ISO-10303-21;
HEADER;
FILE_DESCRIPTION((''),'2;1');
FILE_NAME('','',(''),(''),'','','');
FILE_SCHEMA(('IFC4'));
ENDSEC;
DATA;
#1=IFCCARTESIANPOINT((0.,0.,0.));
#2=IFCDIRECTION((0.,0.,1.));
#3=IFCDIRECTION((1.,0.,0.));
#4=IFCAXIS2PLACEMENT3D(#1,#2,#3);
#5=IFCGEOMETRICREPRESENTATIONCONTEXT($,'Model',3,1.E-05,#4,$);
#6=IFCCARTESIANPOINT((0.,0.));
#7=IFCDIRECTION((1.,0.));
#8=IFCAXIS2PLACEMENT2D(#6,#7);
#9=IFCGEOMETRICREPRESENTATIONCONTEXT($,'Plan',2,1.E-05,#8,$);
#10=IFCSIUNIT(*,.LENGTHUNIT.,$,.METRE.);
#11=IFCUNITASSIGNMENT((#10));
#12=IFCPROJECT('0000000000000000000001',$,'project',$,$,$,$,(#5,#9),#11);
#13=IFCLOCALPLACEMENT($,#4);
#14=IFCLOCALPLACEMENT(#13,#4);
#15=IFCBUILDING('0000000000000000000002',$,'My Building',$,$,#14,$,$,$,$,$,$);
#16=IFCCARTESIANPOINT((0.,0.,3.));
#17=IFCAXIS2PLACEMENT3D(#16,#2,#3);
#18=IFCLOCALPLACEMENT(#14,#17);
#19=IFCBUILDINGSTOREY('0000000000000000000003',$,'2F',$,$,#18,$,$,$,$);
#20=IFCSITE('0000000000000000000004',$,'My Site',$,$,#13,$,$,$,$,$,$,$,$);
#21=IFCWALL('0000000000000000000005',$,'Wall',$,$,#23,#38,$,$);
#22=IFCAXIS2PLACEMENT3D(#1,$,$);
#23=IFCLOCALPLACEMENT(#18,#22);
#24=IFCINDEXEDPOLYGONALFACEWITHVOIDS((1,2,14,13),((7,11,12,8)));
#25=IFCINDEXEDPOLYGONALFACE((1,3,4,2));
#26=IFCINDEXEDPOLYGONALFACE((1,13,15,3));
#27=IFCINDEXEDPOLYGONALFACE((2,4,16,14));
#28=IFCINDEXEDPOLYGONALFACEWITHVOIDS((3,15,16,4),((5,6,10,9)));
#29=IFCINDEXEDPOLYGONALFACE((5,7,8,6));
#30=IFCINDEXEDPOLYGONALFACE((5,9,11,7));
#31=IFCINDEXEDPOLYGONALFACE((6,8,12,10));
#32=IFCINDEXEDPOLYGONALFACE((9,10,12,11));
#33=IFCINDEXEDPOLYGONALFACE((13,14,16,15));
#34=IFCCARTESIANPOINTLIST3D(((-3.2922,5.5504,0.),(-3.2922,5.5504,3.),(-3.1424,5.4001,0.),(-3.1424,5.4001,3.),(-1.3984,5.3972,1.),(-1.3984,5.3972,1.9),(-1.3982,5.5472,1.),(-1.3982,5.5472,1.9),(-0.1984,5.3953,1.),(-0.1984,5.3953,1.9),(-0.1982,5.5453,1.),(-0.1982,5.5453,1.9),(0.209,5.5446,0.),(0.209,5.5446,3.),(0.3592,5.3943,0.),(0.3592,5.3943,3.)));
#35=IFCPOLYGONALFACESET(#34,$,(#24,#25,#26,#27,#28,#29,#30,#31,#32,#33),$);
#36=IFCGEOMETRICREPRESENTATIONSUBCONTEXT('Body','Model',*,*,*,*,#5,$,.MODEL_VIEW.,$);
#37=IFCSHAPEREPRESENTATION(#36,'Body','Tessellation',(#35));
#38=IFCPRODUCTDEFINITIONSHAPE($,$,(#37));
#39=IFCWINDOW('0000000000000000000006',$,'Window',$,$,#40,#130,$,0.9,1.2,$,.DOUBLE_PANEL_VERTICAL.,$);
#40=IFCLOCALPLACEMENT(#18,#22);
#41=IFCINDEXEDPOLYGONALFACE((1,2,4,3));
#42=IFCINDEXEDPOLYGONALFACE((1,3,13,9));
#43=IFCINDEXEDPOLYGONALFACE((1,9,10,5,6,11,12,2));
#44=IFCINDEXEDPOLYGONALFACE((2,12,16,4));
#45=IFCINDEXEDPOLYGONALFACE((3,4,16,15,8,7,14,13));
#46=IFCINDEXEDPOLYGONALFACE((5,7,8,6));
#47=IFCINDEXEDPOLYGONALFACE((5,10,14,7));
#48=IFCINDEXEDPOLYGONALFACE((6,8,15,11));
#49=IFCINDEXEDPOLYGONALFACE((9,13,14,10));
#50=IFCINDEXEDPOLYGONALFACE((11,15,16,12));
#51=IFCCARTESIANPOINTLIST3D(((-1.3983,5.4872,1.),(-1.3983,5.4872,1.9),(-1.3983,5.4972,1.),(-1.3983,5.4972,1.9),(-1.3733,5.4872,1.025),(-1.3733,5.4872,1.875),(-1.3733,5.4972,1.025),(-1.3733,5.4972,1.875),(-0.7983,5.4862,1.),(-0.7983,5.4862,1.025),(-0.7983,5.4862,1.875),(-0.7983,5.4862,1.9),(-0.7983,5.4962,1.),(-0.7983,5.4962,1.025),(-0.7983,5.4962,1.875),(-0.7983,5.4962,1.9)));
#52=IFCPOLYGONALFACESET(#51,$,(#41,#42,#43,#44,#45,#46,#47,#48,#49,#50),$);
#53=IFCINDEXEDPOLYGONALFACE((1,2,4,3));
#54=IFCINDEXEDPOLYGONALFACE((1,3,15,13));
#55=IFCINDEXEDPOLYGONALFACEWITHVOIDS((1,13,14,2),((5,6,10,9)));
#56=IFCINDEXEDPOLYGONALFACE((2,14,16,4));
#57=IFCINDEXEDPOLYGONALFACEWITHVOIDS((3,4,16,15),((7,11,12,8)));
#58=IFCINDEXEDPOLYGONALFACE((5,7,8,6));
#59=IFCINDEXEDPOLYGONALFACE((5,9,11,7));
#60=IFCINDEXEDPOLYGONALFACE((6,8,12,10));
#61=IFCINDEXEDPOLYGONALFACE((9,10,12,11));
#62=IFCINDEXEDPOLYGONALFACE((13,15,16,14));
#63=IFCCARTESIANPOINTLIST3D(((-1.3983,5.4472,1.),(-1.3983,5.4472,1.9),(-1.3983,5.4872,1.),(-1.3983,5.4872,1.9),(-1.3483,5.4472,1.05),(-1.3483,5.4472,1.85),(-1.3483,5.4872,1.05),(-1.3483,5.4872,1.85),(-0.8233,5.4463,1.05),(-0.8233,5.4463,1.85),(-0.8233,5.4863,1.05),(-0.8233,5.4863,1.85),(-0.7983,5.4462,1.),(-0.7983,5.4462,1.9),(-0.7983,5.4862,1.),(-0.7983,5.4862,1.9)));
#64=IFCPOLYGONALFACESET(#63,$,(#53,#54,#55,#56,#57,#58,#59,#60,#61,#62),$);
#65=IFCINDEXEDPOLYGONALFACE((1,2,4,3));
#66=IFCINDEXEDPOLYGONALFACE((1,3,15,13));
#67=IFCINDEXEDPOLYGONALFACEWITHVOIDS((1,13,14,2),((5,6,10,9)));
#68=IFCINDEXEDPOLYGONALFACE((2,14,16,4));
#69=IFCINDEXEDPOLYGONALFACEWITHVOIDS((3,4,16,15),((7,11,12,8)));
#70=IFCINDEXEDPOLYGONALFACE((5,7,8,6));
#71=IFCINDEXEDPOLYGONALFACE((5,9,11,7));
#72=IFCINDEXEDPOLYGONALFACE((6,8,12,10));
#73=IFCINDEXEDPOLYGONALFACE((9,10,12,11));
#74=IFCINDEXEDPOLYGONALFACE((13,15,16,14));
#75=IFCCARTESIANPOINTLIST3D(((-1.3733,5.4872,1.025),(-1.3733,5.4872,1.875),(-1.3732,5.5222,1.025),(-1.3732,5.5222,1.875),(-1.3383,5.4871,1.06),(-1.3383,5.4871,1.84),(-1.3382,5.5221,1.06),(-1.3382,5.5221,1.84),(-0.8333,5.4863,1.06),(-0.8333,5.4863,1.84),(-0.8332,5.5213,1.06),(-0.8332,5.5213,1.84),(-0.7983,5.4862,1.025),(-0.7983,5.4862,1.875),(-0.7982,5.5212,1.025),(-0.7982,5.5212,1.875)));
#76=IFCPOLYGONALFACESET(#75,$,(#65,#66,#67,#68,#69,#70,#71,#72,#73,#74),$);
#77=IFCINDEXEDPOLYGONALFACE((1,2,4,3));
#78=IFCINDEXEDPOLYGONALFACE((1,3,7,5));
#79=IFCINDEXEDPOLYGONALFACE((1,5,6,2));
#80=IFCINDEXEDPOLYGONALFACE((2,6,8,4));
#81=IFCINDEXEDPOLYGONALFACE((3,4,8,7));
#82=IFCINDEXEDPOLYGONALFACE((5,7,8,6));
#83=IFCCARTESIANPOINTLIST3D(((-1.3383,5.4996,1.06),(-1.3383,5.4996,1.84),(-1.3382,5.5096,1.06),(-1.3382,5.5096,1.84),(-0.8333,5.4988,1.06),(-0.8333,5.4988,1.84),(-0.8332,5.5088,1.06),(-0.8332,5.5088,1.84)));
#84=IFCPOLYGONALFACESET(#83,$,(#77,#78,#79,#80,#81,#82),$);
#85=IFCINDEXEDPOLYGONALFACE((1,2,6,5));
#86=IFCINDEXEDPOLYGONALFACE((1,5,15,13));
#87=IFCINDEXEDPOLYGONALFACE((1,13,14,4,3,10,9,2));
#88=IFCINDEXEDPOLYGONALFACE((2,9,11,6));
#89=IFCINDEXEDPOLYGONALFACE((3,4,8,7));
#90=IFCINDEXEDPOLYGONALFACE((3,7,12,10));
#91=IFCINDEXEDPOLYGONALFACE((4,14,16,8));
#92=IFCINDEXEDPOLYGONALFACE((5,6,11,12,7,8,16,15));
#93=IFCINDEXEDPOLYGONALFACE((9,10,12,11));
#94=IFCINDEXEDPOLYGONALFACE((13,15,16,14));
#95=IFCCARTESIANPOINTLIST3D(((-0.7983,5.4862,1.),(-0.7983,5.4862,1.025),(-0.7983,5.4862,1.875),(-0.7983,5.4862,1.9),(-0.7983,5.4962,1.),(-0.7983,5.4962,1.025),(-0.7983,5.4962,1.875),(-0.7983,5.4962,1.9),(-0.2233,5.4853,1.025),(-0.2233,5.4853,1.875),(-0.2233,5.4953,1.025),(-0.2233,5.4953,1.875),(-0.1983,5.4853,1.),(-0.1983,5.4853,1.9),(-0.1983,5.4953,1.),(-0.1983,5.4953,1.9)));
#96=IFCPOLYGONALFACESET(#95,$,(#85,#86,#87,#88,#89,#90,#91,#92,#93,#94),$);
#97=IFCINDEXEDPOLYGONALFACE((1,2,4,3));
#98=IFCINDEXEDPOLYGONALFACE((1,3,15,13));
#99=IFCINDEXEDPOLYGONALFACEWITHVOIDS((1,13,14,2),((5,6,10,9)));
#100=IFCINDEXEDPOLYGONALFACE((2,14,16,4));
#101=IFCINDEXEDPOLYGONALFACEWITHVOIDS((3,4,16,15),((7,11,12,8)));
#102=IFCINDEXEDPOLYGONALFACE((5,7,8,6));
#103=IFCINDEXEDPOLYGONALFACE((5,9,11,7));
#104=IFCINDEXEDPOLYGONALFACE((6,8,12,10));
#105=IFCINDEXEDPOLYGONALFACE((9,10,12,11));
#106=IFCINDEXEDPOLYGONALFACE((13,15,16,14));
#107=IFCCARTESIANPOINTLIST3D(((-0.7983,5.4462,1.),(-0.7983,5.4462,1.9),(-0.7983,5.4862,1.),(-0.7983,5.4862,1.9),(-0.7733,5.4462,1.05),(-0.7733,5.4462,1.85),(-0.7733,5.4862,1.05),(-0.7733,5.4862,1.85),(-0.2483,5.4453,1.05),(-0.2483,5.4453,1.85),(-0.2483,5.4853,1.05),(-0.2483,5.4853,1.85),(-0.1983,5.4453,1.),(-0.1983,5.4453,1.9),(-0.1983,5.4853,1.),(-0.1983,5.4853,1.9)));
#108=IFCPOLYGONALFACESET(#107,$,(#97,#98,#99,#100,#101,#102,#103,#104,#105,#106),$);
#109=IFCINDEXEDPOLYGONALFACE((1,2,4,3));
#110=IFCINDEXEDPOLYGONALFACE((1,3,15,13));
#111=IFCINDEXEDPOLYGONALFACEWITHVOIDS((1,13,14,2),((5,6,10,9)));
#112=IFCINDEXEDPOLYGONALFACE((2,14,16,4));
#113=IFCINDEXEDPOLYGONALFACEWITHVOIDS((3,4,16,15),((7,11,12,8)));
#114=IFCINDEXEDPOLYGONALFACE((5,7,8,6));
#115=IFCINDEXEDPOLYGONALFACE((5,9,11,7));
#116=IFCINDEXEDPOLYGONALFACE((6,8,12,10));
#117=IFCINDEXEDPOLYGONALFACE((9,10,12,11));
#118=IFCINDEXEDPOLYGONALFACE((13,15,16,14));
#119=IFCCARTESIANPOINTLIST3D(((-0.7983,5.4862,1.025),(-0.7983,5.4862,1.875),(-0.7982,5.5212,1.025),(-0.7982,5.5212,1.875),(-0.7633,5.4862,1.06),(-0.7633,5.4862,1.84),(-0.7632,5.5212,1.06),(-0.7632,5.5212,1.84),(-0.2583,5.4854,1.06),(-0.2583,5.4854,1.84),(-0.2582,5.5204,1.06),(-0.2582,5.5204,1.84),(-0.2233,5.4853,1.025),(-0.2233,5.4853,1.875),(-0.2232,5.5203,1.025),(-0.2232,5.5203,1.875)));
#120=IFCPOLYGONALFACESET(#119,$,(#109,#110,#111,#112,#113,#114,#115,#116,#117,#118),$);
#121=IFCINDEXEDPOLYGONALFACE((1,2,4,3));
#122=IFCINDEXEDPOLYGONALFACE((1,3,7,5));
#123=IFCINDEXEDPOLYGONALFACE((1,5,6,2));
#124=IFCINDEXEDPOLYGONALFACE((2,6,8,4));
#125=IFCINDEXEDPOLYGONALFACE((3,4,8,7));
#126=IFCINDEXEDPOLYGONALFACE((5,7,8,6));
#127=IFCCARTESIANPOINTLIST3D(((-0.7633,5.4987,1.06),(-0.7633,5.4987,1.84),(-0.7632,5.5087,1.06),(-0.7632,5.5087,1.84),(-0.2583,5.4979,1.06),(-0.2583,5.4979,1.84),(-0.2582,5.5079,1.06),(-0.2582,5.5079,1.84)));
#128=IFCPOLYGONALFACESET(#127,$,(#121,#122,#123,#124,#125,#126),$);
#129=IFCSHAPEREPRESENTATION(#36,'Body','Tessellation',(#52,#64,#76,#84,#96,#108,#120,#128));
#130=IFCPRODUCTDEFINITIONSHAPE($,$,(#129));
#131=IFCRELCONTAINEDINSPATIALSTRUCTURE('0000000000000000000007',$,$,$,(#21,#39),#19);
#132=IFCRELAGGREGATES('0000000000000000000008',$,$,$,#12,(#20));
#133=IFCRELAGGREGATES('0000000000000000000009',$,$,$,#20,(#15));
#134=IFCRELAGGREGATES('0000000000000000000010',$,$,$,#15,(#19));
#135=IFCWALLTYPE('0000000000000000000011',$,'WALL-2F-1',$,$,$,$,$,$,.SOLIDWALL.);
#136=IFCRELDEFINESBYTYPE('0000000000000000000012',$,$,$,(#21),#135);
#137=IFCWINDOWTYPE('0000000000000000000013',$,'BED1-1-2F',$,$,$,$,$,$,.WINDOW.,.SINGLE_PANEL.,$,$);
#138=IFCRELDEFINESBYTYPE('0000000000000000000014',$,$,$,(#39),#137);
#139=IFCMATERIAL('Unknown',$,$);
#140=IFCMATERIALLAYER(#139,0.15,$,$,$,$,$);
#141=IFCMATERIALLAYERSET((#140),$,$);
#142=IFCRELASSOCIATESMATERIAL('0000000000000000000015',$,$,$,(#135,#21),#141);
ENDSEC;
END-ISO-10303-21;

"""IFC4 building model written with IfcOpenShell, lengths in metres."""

from ifc_helpers import new_model, entity, si_unit, frame, origin_with_axes, origin_2d_with_axis, place, context, subcontext, project, spatial, line, indexed_curve, outline, extrude, shape, source, transform, mapped, material, layer, layer_set, layer_usage, type_object, type_shapes, element, fill, save


model = new_model("IFC4")

# Units and contexts
model_context = context("Model", 3, precision=1e-05, world=origin_with_axes())
plan_context = context("Plan", 2, precision=1e-05, world=origin_2d_with_axis())
body_context_1 = subcontext(model_context, "Body", "Model", "MODEL_VIEW")
body_context_2 = subcontext(plan_context, "Body", "Plan", "PLAN_VIEW")
ifc_project = project(units=[si_unit("LENGTHUNIT", "METRE")], contexts=[model_context, plan_context])

# Site, building, storey
site_placement = place(None, origin_with_axes())
site = spatial("IfcSite", under=ifc_project, at=site_placement, Name="My Site")
building_placement = place(site_placement, origin_with_axes())
building = spatial("IfcBuilding", under=site, at=building_placement, Name="My Building")
storey_placement = place(building_placement, frame((0.0, 0.0, 3.0), z_axis=(0.0, 0.0, 1.0), x_axis=(1.0, 0.0, 0.0)))
storey = spatial("IfcBuildingStorey", under=building, at=storey_placement, Name="2F")

# Shared definitions
ifc_material = material(Name="Unknown")

# Shared definitions
ifc_layer_1 = layer(ifc_material, 0.15)
ifc_layer_set_1 = layer_set([ifc_layer_1])
wall_type_1 = type_object("IfcWallType", Name="WALL-2F-1", PredefinedType="SOLIDWALL", material=ifc_layer_set_1)

# Wall, opening, window
ifc_layer_usage_1 = layer_usage(ifc_layer_set_1, "AXIS2", "POSITIVE", 0.0)
wall_1_placement = place(storey_placement, frame((0.209, 5.5446, 0.0), z_axis=(0.0, 0.0, 1.0), x_axis=(-0.999999, 0.001662, 0.0)))
wall_1 = element("IfcWall", 1, at=wall_1_placement, inside=storey, type_object=wall_type_1, material=ifc_layer_usage_1, Name="Wall", context=body_context_1, shape_type="SweptSolid", body=[
    extrude(outline(indexed_curve([(0.0, 0.0), (-0.1504, 0.15), (3.3512, 0.15), (3.5012, 0.0)], segments=[line(1, 2, 3, 4, 1)])), origin_with_axes(), (0.0, 0.0, 1.0), 3.0),
])
shared_shape_1 = source(origin_with_axes(), body_context_1, "Body", "SweptSolid", [
    extrude(outline(indexed_curve([(0.0, 0.0), (1.2, 0.0), (1.2, 0.9), (0.0, 0.9)], segments=[line(1, 2, 3, 4, 1)])), frame((0.0, -0.6, 0.0), z_axis=(0.0, -1.0, 0.0), x_axis=(1.0, 0.0, 0.0)), (0.0, 0.0, -1.0), 1.2),
])
opening_1_placement = place(wall_1_placement, frame((1.6072, 0.15, 1.0), z_axis=(0.0, 0.0, 1.0), x_axis=(-1.0, 0.0, 0.0)))
opening_1 = element("IfcOpeningElement", 2, at=opening_1_placement, cuts=wall_1, PredefinedType="OPENING", context=body_context_1, shape_type="MappedRepresentation", body=[
    mapped(shared_shape_1, transform((0.0, 0.0, 0.0), x_axis=(1.0, 0.0, 0.0), y_axis=(0.0, 1.0, 0.0), z_axis=(0.0, 0.0, 1.0), scale=1.0)),
])
window_type_1 = type_object("IfcWindowType", Name="BED1-1-2F", PartitioningType="SINGLE_PANEL", PredefinedType="WINDOW")
shared_shape_2 = source(origin_with_axes(), body_context_1, "Body", "SweptSolid", [
    extrude(outline(indexed_curve([(0.6, 0.0), (0.0, 0.0), (0.0, 0.9), (0.6, 0.9), (0.6, 0.875), (0.025, 0.875), (0.025, 0.025), (0.6, 0.025)], segments=[line(1, 2, 3, 4, 5, 6, 7, 8, 1)])), frame((0.0, 0.09, 0.0), z_axis=(0.0, -1.0, 0.0), x_axis=(1.0, 0.0, 0.0)), (0.0, 0.0, -1.0), 0.01),
    extrude(outline(indexed_curve([(0.0, 0.0), (0.6, 0.0), (0.6, 0.9), (0.0, 0.9)], segments=[line(1, 2, 3, 4, 1)]), holes=[indexed_curve([(0.05, 0.05), (0.575, 0.05), (0.575, 0.85), (0.05, 0.85)], segments=[line(1, 2, 3, 4, 1)])]), frame((0.0, 0.05, 0.0), z_axis=(0.0, -1.0, 0.0), x_axis=(1.0, 0.0, 0.0)), (0.0, 0.0, -1.0), 0.04),
    extrude(outline(indexed_curve([(0.0, 0.0), (0.575, 0.0), (0.575, 0.85), (0.0, 0.85)], segments=[line(1, 2, 3, 4, 1)]), holes=[indexed_curve([(0.035, 0.035), (0.54, 0.035), (0.54, 0.815), (0.035, 0.815)], segments=[line(1, 2, 3, 4, 1)])]), frame((0.025, 0.09, 0.025), z_axis=(0.0, -1.0, 0.0), x_axis=(1.0, 0.0, 0.0)), (0.0, 0.0, -1.0), 0.035),
    extrude(outline(indexed_curve([(0.035, 0.035), (0.54, 0.035), (0.54, 0.815), (0.035, 0.815)], segments=[line(1, 2, 3, 4, 1)])), frame((0.025, 0.1025, 0.025), z_axis=(0.0, -1.0, 0.0), x_axis=(1.0, 0.0, 0.0)), (0.0, 0.0, -1.0), 0.01),
    extrude(outline(indexed_curve([(0.0, 0.9), (0.6, 0.9), (0.6, 0.0), (0.0, 0.0), (0.0, 0.025), (0.575, 0.025), (0.575, 0.875), (0.0, 0.875)], segments=[line(1, 2, 3, 4, 5, 6, 7, 8, 1)])), frame((0.6, 0.09, 0.0), z_axis=(0.0, -1.0, 0.0), x_axis=(1.0, 0.0, 0.0)), (0.0, 0.0, -1.0), 0.01),
    extrude(outline(indexed_curve([(0.0, 0.0), (0.6, 0.0), (0.6, 0.9), (0.0, 0.9)], segments=[line(1, 2, 3, 4, 1)]), holes=[indexed_curve([(0.025, 0.05), (0.55, 0.05), (0.55, 0.85), (0.025, 0.85)], segments=[line(1, 2, 3, 4, 1)])]), frame((0.6, 0.05, 0.0), z_axis=(0.0, -1.0, 0.0), x_axis=(1.0, 0.0, 0.0)), (0.0, 0.0, -1.0), 0.04),
    extrude(outline(indexed_curve([(0.0, 0.0), (0.575, 0.0), (0.575, 0.85), (0.0, 0.85)], segments=[line(1, 2, 3, 4, 1)]), holes=[indexed_curve([(0.035, 0.035), (0.54, 0.035), (0.54, 0.815), (0.035, 0.815)], segments=[line(1, 2, 3, 4, 1)])]), frame((0.6, 0.09, 0.025), z_axis=(0.0, -1.0, 0.0), x_axis=(1.0, 0.0, 0.0)), (0.0, 0.0, -1.0), 0.035),
    extrude(outline(indexed_curve([(0.035, 0.035), (0.54, 0.035), (0.54, 0.815), (0.035, 0.815)], segments=[line(1, 2, 3, 4, 1)])), frame((0.6, 0.1025, 0.025), z_axis=(0.0, -1.0, 0.0), x_axis=(1.0, 0.0, 0.0)), (0.0, 0.0, -1.0), 0.01),
])
shared_shape_3 = source(origin_with_axes(), body_context_2, "Body", "Curve2D", [
    entity("IfcIndexedPolyCurve", entity("IfcCartesianPointList2D", [[0.05, 0.05], [0.575, 0.05]])),
    entity("IfcIndexedPolyCurve", entity("IfcCartesianPointList2D", [[0.0, 0.1], [0.025, 0.1], [0.025, 0.09], [0.05, 0.09], [0.05, 0.05], [0.0, 0.05]]), [entity("IfcLineIndex", [1, 2, 3, 4, 5, 6, 1])]),
    entity("IfcIndexedPolyCurve", entity("IfcCartesianPointList2D", [[0.6, 0.1], [0.6, 0.1], [0.6, 0.09], [0.575, 0.09], [0.575, 0.05], [0.6, 0.05]])),
    entity("IfcIndexedPolyCurve", entity("IfcCartesianPointList2D", [[0.025, 0.09], [0.06, 0.09], [0.06, 0.125], [0.025, 0.125]]), [entity("IfcLineIndex", [1, 2, 3, 4, 1])]),
    entity("IfcIndexedPolyCurve", entity("IfcCartesianPointList2D", [[0.6, 0.09], [0.565, 0.09], [0.565, 0.125], [0.6, 0.125]]), [entity("IfcLineIndex", [1, 2, 3, 4, 1])]),
    entity("IfcIndexedPolyCurve", entity("IfcCartesianPointList2D", [[0.06, 0.09], [0.565, 0.09]])),
    entity("IfcIndexedPolyCurve", entity("IfcCartesianPointList2D", [[0.06, 0.125], [0.565, 0.125]])),
    entity("IfcIndexedPolyCurve", entity("IfcCartesianPointList2D", [[0.06, 0.1075], [0.565, 0.1075]])),
    entity("IfcIndexedPolyCurve", entity("IfcCartesianPointList2D", [[0.625, 0.05], [1.15, 0.05]])),
    entity("IfcIndexedPolyCurve", entity("IfcCartesianPointList2D", [[0.6, 0.1], [0.6, 0.1], [0.6, 0.09], [0.625, 0.09], [0.625, 0.05], [0.6, 0.05]])),
    entity("IfcIndexedPolyCurve", entity("IfcCartesianPointList2D", [[1.2, 0.1], [1.175, 0.1], [1.175, 0.09], [1.15, 0.09], [1.15, 0.05], [1.2, 0.05]]), [entity("IfcLineIndex", [1, 2, 3, 4, 5, 6, 1])]),
    entity("IfcIndexedPolyCurve", entity("IfcCartesianPointList2D", [[0.6, 0.09], [0.635, 0.09], [0.635, 0.125], [0.6, 0.125]]), [entity("IfcLineIndex", [1, 2, 3, 4, 1])]),
    entity("IfcIndexedPolyCurve", entity("IfcCartesianPointList2D", [[1.175, 0.09], [1.14, 0.09], [1.14, 0.125], [1.175, 0.125]]), [entity("IfcLineIndex", [1, 2, 3, 4, 1])]),
    entity("IfcIndexedPolyCurve", entity("IfcCartesianPointList2D", [[0.635, 0.09], [1.14, 0.09]])),
    entity("IfcIndexedPolyCurve", entity("IfcCartesianPointList2D", [[0.635, 0.125], [1.14, 0.125]])),
    entity("IfcIndexedPolyCurve", entity("IfcCartesianPointList2D", [[0.635, 0.1075], [1.14, 0.1075]])),
])
type_shapes(window_type_1, [shared_shape_2, shared_shape_3])
window_1_placement = place(opening_1_placement, frame((0.0, 0.0, 0.0), z_axis=(0.0, 0.0, 1.0), x_axis=(1.0, 0.0, 0.0)))
window_1 = element("IfcWindow", 3, at=window_1_placement, inside=storey, type_object=window_type_1, Name="Window", OverallHeight=0.9, OverallWidth=1.2, PartitioningType="DOUBLE_PANEL_VERTICAL", shapes=[
    shape(body_context_1, "Body", "MappedRepresentation", [mapped(shared_shape_2, transform((0.0, 0.0, 0.0), x_axis=(1.0, 0.0, 0.0), y_axis=(0.0, 1.0, 0.0), z_axis=(0.0, 0.0, 1.0), scale=1.0))]),
    shape(body_context_2, "Body", "MappedRepresentation", [mapped(shared_shape_3, transform((0.0, 0.0, 0.0), x_axis=(1.0, 0.0, 0.0), y_axis=(0.0, 1.0, 0.0), z_axis=(0.0, 0.0, 1.0), scale=1.0))]),
])
fill(opening_1, window_1)

save(model, "model.ifc")
